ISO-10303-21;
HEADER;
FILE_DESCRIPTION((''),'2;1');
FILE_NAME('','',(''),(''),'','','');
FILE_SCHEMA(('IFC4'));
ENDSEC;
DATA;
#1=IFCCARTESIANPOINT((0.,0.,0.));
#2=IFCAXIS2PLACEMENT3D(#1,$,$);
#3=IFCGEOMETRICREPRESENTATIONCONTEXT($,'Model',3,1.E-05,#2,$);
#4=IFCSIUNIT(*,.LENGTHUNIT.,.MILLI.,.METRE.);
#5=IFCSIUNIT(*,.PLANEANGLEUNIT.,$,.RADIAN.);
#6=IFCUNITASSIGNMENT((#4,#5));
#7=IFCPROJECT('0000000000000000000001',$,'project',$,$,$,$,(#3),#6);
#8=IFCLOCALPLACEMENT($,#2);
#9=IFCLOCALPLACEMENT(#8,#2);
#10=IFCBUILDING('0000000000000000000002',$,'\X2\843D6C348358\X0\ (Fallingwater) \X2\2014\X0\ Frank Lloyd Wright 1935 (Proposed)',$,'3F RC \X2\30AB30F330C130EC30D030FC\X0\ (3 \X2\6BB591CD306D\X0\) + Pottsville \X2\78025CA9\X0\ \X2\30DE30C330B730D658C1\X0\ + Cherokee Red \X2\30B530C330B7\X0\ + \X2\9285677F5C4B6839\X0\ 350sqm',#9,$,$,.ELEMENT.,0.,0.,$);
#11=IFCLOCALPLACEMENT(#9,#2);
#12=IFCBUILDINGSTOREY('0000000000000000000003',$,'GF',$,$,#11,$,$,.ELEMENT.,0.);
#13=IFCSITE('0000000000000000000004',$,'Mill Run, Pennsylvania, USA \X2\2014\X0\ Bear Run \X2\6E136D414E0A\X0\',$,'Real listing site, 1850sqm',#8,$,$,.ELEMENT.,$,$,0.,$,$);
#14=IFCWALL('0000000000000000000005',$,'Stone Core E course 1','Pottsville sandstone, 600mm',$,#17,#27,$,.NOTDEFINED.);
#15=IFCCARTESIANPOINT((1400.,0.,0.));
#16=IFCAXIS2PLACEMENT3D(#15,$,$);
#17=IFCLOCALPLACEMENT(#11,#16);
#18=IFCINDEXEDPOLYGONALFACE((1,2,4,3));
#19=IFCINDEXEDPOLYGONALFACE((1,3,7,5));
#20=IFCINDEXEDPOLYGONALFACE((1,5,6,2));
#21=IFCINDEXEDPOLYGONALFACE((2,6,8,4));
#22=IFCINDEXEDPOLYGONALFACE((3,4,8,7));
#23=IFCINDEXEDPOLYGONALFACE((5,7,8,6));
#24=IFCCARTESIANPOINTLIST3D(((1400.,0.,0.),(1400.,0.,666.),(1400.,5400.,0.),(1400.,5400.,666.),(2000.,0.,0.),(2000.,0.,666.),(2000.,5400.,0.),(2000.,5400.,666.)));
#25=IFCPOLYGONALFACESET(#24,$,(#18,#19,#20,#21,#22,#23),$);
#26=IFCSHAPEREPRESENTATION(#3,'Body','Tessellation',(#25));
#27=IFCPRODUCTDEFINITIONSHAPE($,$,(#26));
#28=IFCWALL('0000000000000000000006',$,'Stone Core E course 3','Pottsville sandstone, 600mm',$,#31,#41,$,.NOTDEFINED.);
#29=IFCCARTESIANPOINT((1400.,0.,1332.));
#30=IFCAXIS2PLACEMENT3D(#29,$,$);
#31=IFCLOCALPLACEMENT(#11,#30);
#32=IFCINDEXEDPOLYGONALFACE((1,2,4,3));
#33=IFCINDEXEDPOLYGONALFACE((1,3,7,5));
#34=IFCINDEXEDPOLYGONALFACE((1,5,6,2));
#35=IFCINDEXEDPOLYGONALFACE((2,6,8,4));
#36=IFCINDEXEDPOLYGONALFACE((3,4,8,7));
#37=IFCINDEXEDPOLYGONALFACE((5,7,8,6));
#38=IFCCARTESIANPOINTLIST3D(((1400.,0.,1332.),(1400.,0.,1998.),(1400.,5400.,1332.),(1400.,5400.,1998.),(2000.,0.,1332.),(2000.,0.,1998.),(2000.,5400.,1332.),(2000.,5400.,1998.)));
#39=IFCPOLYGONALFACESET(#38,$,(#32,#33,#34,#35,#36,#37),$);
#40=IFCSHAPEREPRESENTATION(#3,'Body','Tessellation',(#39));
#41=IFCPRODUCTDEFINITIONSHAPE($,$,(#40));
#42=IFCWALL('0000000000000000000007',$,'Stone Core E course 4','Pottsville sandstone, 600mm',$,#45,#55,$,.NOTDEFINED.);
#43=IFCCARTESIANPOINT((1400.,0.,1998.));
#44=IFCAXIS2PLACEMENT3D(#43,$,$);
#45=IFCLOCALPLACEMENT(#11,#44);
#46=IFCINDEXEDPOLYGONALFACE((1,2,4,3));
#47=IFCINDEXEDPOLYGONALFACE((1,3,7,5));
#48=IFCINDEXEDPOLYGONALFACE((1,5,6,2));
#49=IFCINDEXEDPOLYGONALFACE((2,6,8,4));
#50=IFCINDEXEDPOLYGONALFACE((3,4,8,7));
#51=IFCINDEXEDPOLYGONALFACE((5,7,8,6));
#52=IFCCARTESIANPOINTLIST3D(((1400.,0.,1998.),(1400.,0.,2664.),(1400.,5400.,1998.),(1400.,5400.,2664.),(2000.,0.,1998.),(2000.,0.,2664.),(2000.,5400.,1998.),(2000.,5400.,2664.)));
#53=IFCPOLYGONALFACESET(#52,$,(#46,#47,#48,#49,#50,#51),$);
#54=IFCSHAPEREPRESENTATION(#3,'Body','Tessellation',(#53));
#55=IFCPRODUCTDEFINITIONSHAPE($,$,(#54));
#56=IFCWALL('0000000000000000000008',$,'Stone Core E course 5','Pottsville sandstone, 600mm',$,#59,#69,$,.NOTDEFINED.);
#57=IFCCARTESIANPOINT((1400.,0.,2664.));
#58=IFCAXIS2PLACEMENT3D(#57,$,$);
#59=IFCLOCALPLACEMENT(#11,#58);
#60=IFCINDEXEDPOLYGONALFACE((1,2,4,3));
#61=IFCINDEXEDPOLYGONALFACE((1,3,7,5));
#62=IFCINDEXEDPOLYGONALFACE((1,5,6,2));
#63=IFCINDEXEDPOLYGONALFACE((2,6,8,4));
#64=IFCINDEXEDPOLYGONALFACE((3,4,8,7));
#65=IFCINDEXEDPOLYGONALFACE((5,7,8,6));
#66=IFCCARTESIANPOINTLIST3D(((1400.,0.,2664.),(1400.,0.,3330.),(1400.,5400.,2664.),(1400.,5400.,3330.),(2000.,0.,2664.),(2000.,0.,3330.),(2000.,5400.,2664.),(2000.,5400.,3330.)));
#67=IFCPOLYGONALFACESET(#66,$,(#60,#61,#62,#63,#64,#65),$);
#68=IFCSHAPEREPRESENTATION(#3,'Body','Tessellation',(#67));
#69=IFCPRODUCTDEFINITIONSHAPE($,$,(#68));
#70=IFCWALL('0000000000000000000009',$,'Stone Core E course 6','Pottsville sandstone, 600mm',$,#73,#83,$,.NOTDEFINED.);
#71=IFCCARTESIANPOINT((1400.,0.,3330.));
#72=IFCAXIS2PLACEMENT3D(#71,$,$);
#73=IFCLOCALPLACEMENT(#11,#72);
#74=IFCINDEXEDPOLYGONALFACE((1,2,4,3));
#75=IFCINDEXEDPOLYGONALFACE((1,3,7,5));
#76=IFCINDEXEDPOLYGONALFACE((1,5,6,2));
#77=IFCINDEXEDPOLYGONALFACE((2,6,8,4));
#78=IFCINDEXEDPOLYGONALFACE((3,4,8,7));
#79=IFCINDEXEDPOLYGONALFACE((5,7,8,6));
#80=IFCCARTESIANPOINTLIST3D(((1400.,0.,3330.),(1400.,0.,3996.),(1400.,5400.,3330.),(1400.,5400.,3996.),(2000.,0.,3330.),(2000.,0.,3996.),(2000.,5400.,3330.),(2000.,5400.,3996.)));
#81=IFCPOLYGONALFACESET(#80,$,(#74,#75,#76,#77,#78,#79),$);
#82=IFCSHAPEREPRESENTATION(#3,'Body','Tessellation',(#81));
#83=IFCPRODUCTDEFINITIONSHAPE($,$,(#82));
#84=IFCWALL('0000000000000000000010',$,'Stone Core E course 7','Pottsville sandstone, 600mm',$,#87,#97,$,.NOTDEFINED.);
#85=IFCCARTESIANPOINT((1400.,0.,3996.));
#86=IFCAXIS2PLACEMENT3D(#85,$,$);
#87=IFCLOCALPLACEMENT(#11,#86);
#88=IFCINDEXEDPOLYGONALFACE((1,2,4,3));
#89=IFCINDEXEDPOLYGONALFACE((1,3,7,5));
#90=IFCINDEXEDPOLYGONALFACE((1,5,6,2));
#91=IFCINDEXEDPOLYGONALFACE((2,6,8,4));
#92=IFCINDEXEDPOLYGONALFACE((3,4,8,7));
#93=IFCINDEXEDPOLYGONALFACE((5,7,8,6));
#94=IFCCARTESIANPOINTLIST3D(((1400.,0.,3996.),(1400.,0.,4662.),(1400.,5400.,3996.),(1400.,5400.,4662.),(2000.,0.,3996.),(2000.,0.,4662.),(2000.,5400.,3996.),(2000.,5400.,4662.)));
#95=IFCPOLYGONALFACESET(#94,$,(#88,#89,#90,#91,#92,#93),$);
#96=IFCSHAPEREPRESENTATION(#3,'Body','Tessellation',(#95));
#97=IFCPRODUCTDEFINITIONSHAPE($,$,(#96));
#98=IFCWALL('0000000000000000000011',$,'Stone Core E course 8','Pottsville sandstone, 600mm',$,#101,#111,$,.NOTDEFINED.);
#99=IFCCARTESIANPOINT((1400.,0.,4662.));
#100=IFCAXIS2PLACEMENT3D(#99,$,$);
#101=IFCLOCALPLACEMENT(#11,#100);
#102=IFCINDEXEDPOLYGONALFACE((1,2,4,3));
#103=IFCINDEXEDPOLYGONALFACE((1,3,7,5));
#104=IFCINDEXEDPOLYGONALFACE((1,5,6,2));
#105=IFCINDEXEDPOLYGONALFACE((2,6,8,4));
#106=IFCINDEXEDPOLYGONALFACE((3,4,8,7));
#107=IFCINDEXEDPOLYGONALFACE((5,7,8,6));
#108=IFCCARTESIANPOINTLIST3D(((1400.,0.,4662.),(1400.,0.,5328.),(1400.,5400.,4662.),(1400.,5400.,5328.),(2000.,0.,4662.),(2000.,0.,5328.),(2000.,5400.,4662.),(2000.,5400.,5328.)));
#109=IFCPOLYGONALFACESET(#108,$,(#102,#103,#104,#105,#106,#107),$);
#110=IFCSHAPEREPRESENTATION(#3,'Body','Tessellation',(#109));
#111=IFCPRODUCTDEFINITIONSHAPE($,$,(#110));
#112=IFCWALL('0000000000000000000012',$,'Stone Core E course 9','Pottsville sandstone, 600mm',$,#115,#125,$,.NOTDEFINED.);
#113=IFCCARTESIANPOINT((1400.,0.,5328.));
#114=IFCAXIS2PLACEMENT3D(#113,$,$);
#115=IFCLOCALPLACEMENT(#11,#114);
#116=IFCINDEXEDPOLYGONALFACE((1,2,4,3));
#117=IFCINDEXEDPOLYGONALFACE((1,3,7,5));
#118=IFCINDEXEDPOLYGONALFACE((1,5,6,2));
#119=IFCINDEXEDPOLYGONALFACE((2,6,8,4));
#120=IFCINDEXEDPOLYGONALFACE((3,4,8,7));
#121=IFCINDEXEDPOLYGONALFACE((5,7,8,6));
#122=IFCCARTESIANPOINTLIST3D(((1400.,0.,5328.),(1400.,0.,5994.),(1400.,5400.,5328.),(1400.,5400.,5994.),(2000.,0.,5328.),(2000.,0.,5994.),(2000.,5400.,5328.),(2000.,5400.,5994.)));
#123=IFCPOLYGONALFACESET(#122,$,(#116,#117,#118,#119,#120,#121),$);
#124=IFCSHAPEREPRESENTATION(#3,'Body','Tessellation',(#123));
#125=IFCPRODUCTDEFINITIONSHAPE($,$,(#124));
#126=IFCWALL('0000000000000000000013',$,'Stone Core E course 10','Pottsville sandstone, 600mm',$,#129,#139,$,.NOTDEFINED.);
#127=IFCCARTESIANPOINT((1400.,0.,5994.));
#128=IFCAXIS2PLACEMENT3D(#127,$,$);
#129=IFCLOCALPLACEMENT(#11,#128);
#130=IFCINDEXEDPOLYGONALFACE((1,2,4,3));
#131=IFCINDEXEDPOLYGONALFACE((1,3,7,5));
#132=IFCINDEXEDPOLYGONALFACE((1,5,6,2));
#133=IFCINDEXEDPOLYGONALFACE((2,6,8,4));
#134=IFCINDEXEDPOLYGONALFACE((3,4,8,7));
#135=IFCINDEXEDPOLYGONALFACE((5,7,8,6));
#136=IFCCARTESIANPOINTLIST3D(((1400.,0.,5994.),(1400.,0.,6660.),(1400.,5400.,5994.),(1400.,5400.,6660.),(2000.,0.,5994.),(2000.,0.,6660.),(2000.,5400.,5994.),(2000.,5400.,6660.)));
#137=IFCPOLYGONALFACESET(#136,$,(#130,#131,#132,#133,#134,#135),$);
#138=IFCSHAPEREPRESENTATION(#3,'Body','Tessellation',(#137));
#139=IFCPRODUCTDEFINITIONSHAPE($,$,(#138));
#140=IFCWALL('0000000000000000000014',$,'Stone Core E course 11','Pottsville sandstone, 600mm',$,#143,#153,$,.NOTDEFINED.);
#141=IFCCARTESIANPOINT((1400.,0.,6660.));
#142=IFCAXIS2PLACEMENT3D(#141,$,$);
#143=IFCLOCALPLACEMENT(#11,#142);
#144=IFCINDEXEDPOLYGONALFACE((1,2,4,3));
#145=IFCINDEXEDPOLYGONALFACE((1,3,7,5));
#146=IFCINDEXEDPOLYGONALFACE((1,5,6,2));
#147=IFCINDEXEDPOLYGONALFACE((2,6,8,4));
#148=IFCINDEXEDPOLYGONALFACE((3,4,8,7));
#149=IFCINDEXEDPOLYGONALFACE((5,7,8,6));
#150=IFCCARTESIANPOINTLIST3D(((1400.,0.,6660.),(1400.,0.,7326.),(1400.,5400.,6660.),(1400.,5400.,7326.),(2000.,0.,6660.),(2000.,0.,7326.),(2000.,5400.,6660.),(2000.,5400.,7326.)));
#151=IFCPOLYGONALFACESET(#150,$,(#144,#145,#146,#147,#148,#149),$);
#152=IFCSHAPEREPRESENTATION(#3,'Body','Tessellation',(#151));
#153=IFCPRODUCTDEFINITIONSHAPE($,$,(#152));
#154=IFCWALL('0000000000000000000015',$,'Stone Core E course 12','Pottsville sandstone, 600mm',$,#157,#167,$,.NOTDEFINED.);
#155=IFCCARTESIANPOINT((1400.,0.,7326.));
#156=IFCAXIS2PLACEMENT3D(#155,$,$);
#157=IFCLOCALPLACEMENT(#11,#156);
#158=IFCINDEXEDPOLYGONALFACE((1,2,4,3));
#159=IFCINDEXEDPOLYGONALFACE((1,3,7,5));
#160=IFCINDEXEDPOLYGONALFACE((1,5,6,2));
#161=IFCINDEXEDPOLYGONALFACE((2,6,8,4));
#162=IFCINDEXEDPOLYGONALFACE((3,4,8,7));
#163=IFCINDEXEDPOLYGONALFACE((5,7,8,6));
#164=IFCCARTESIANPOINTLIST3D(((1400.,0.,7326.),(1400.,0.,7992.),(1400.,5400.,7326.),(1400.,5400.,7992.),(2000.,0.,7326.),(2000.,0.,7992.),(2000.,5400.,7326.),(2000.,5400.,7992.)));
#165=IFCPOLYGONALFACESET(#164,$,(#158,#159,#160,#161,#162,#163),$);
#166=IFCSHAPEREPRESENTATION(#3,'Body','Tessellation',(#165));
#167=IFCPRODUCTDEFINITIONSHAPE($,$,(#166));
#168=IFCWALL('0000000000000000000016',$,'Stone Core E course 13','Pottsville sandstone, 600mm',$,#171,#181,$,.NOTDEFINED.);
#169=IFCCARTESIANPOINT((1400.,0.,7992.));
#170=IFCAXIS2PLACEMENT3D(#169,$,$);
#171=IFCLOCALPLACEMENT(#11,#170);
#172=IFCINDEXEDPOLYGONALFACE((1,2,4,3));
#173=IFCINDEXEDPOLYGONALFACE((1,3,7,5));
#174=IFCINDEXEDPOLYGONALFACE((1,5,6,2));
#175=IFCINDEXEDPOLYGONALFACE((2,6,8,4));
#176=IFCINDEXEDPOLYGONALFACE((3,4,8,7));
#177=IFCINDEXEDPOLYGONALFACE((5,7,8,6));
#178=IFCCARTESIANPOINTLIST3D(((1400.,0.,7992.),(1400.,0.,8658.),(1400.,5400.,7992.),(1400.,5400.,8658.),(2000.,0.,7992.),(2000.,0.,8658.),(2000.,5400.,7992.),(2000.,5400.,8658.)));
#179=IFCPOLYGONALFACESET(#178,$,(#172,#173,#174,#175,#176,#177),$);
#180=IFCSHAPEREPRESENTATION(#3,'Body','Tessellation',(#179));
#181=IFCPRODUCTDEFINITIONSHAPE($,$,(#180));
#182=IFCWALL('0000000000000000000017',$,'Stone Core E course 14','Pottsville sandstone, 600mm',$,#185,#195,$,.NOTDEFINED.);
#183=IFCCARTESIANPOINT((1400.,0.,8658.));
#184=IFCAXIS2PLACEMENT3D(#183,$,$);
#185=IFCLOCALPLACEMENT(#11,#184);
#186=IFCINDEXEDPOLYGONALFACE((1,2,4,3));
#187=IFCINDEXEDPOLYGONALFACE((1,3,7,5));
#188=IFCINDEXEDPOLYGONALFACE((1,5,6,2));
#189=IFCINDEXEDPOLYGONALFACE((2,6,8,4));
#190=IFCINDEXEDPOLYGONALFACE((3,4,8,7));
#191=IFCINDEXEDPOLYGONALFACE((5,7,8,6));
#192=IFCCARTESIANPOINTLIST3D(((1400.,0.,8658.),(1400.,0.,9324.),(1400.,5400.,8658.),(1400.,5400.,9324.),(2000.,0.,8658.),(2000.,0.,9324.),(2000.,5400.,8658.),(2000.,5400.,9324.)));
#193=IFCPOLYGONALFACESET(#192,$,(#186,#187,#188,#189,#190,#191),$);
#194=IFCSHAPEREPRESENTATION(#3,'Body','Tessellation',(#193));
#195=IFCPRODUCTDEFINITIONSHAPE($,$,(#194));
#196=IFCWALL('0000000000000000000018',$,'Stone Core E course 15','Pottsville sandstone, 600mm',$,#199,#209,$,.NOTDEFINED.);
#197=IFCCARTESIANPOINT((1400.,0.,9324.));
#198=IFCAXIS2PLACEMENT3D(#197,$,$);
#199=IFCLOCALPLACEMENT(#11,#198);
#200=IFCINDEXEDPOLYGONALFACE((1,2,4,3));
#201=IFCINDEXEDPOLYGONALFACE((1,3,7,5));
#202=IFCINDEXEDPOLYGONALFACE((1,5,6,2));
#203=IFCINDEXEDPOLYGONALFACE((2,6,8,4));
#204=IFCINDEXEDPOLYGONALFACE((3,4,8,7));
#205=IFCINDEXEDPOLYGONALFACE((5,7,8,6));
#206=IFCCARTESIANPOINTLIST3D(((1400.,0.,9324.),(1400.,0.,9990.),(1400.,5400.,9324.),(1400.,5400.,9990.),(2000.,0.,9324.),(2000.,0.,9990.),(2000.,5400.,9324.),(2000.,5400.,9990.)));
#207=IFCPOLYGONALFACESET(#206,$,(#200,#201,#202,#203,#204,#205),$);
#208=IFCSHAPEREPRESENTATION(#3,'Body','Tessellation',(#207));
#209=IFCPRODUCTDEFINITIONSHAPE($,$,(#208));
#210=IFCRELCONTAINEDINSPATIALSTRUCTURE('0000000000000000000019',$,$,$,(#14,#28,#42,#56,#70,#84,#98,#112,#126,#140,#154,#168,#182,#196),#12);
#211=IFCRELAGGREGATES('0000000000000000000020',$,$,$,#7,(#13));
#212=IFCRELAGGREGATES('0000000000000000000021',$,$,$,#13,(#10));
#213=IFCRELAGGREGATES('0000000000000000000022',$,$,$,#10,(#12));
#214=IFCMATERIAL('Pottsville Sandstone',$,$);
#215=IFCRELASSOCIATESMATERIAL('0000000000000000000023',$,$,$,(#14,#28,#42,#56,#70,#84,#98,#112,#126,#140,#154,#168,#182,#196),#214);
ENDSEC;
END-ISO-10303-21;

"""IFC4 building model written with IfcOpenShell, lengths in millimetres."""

from ifc_helpers import new_model, si_unit, frame, frame_2d, origin, place, context, project, spatial, rectangle, extrude, material, element, save


model = new_model("IFC4")

# Units and contexts
model_context = context("Model", 3, precision=1e-05, world=origin())
ifc_project = project(units=[si_unit("LENGTHUNIT", "METRE", prefix="MILLI"), si_unit("PLANEANGLEUNIT", "RADIAN")], contexts=[model_context])

# Site, building, storey
site_placement = place(None, origin())
site = spatial("IfcSite", under=ifc_project, at=site_placement, Name="Mill Run, Pennsylvania, USA — Bear Run 渓流上", ObjectType="Real listing site, 1850sqm", CompositionType="ELEMENT", RefElevation=0.0)
building_placement = place(site_placement, origin())
building = spatial("IfcBuilding", under=site, at=building_placement, Name="落水荘 (Fallingwater) — Frank Lloyd Wright 1935 (Proposed)", ObjectType="3F RC カンチレバー (3 段重ね) + Pottsville 砂岩 マッシブ壁 + Cherokee Red サッシ + 銅板屋根 350sqm", CompositionType="ELEMENT", ElevationOfRefHeight=0.0, ElevationOfTerrain=0.0)
storey_placement = place(building_placement, origin())
storey = spatial("IfcBuildingStorey", under=building, at=storey_placement, Name="GF", CompositionType="ELEMENT", Elevation=0.0)

# Walls
ifc_material_1 = material(Name="Pottsville Sandstone")
wall_1_placement = place(storey_placement, frame((1400.0, 0.0, 0.0)))
element("IfcWall", 1, at=wall_1_placement, inside=storey, material=ifc_material_1, Name="Stone Core E course 1", Description="Pottsville sandstone, 600mm", PredefinedType="NOTDEFINED", context=model_context, shape_type="SweptSolid", body=[
    extrude(rectangle(XDim=600.0, YDim=5400.0, at=frame_2d((300.0, 2700.0))), frame((1400.0, 0.0, 0.0)), (0.0, 0.0, 1.0), 666.0),
])
wall_2_placement = place(storey_placement, frame((1400.0, 0.0, 1332.0)))
element("IfcWall", 2, at=wall_2_placement, inside=storey, material=ifc_material_1, Name="Stone Core E course 3", Description="Pottsville sandstone, 600mm", PredefinedType="NOTDEFINED", context=model_context, shape_type="SweptSolid", body=[
    extrude(rectangle(XDim=600.0, YDim=5400.0, at=frame_2d((300.0, 2700.0))), frame((1400.0, 0.0, 1332.0)), (0.0, 0.0, 1.0), 666.0),
])
wall_3_placement = place(storey_placement, frame((1400.0, 0.0, 1998.0)))
element("IfcWall", 3, at=wall_3_placement, inside=storey, material=ifc_material_1, Name="Stone Core E course 4", Description="Pottsville sandstone, 600mm", PredefinedType="NOTDEFINED", context=model_context, shape_type="SweptSolid", body=[
    extrude(rectangle(XDim=600.0, YDim=5400.0, at=frame_2d((300.0, 2700.0))), frame((1400.0, 0.0, 1998.0)), (0.0, 0.0, 1.0), 666.0),
])
wall_4_placement = place(storey_placement, frame((1400.0, 0.0, 2664.0)))
element("IfcWall", 4, at=wall_4_placement, inside=storey, material=ifc_material_1, Name="Stone Core E course 5", Description="Pottsville sandstone, 600mm", PredefinedType="NOTDEFINED", context=model_context, shape_type="SweptSolid", body=[
    extrude(rectangle(XDim=600.0, YDim=5400.0, at=frame_2d((300.0, 2700.0))), frame((1400.0, 0.0, 2664.0)), (0.0, 0.0, 1.0), 666.0),
])
wall_5_placement = place(storey_placement, frame((1400.0, 0.0, 3330.0)))
element("IfcWall", 5, at=wall_5_placement, inside=storey, material=ifc_material_1, Name="Stone Core E course 6", Description="Pottsville sandstone, 600mm", PredefinedType="NOTDEFINED", context=model_context, shape_type="SweptSolid", body=[
    extrude(rectangle(XDim=600.0, YDim=5400.0, at=frame_2d((300.0, 2700.0))), frame((1400.0, 0.0, 3330.0)), (0.0, 0.0, 1.0), 666.0),
])
wall_6_placement = place(storey_placement, frame((1400.0, 0.0, 3996.0)))
element("IfcWall", 6, at=wall_6_placement, inside=storey, material=ifc_material_1, Name="Stone Core E course 7", Description="Pottsville sandstone, 600mm", PredefinedType="NOTDEFINED", context=model_context, shape_type="SweptSolid", body=[
    extrude(rectangle(XDim=600.0, YDim=5400.0, at=frame_2d((300.0, 2700.0))), frame((1400.0, 0.0, 3996.0)), (0.0, 0.0, 1.0), 666.0),
])
wall_7_placement = place(storey_placement, frame((1400.0, 0.0, 4662.0)))
element("IfcWall", 7, at=wall_7_placement, inside=storey, material=ifc_material_1, Name="Stone Core E course 8", Description="Pottsville sandstone, 600mm", PredefinedType="NOTDEFINED", context=model_context, shape_type="SweptSolid", body=[
    extrude(rectangle(XDim=600.0, YDim=5400.0, at=frame_2d((300.0, 2700.0))), frame((1400.0, 0.0, 4662.0)), (0.0, 0.0, 1.0), 666.0),
])
wall_8_placement = place(storey_placement, frame((1400.0, 0.0, 5328.0)))
element("IfcWall", 8, at=wall_8_placement, inside=storey, material=ifc_material_1, Name="Stone Core E course 9", Description="Pottsville sandstone, 600mm", PredefinedType="NOTDEFINED", context=model_context, shape_type="SweptSolid", body=[
    extrude(rectangle(XDim=600.0, YDim=5400.0, at=frame_2d((300.0, 2700.0))), frame((1400.0, 0.0, 5328.0)), (0.0, 0.0, 1.0), 666.0),
])
wall_9_placement = place(storey_placement, frame((1400.0, 0.0, 5994.0)))
element("IfcWall", 9, at=wall_9_placement, inside=storey, material=ifc_material_1, Name="Stone Core E course 10", Description="Pottsville sandstone, 600mm", PredefinedType="NOTDEFINED", context=model_context, shape_type="SweptSolid", body=[
    extrude(rectangle(XDim=600.0, YDim=5400.0, at=frame_2d((300.0, 2700.0))), frame((1400.0, 0.0, 5994.0)), (0.0, 0.0, 1.0), 666.0),
])
wall_10_placement = place(storey_placement, frame((1400.0, 0.0, 6660.0)))
element("IfcWall", 10, at=wall_10_placement, inside=storey, material=ifc_material_1, Name="Stone Core E course 11", Description="Pottsville sandstone, 600mm", PredefinedType="NOTDEFINED", context=model_context, shape_type="SweptSolid", body=[
    extrude(rectangle(XDim=600.0, YDim=5400.0, at=frame_2d((300.0, 2700.0))), frame((1400.0, 0.0, 6660.0)), (0.0, 0.0, 1.0), 666.0),
])
wall_11_placement = place(storey_placement, frame((1400.0, 0.0, 7326.0)))
element("IfcWall", 11, at=wall_11_placement, inside=storey, material=ifc_material_1, Name="Stone Core E course 12", Description="Pottsville sandstone, 600mm", PredefinedType="NOTDEFINED", context=model_context, shape_type="SweptSolid", body=[
    extrude(rectangle(XDim=600.0, YDim=5400.0, at=frame_2d((300.0, 2700.0))), frame((1400.0, 0.0, 7326.0)), (0.0, 0.0, 1.0), 666.0),
])
wall_12_placement = place(storey_placement, frame((1400.0, 0.0, 7992.0)))
element("IfcWall", 12, at=wall_12_placement, inside=storey, material=ifc_material_1, Name="Stone Core E course 13", Description="Pottsville sandstone, 600mm", PredefinedType="NOTDEFINED", context=model_context, shape_type="SweptSolid", body=[
    extrude(rectangle(XDim=600.0, YDim=5400.0, at=frame_2d((300.0, 2700.0))), frame((1400.0, 0.0, 7992.0)), (0.0, 0.0, 1.0), 666.0),
])
wall_13_placement = place(storey_placement, frame((1400.0, 0.0, 8658.0)))
element("IfcWall", 13, at=wall_13_placement, inside=storey, material=ifc_material_1, Name="Stone Core E course 14", Description="Pottsville sandstone, 600mm", PredefinedType="NOTDEFINED", context=model_context, shape_type="SweptSolid", body=[
    extrude(rectangle(XDim=600.0, YDim=5400.0, at=frame_2d((300.0, 2700.0))), frame((1400.0, 0.0, 8658.0)), (0.0, 0.0, 1.0), 666.0),
])
wall_14_placement = place(storey_placement, frame((1400.0, 0.0, 9324.0)))
element("IfcWall", 14, at=wall_14_placement, inside=storey, material=ifc_material_1, Name="Stone Core E course 15", Description="Pottsville sandstone, 600mm", PredefinedType="NOTDEFINED", context=model_context, shape_type="SweptSolid", body=[
    extrude(rectangle(XDim=600.0, YDim=5400.0, at=frame_2d((300.0, 2700.0))), frame((1400.0, 0.0, 9324.0)), (0.0, 0.0, 1.0), 666.0),
])

save(model, "model.ifc")
